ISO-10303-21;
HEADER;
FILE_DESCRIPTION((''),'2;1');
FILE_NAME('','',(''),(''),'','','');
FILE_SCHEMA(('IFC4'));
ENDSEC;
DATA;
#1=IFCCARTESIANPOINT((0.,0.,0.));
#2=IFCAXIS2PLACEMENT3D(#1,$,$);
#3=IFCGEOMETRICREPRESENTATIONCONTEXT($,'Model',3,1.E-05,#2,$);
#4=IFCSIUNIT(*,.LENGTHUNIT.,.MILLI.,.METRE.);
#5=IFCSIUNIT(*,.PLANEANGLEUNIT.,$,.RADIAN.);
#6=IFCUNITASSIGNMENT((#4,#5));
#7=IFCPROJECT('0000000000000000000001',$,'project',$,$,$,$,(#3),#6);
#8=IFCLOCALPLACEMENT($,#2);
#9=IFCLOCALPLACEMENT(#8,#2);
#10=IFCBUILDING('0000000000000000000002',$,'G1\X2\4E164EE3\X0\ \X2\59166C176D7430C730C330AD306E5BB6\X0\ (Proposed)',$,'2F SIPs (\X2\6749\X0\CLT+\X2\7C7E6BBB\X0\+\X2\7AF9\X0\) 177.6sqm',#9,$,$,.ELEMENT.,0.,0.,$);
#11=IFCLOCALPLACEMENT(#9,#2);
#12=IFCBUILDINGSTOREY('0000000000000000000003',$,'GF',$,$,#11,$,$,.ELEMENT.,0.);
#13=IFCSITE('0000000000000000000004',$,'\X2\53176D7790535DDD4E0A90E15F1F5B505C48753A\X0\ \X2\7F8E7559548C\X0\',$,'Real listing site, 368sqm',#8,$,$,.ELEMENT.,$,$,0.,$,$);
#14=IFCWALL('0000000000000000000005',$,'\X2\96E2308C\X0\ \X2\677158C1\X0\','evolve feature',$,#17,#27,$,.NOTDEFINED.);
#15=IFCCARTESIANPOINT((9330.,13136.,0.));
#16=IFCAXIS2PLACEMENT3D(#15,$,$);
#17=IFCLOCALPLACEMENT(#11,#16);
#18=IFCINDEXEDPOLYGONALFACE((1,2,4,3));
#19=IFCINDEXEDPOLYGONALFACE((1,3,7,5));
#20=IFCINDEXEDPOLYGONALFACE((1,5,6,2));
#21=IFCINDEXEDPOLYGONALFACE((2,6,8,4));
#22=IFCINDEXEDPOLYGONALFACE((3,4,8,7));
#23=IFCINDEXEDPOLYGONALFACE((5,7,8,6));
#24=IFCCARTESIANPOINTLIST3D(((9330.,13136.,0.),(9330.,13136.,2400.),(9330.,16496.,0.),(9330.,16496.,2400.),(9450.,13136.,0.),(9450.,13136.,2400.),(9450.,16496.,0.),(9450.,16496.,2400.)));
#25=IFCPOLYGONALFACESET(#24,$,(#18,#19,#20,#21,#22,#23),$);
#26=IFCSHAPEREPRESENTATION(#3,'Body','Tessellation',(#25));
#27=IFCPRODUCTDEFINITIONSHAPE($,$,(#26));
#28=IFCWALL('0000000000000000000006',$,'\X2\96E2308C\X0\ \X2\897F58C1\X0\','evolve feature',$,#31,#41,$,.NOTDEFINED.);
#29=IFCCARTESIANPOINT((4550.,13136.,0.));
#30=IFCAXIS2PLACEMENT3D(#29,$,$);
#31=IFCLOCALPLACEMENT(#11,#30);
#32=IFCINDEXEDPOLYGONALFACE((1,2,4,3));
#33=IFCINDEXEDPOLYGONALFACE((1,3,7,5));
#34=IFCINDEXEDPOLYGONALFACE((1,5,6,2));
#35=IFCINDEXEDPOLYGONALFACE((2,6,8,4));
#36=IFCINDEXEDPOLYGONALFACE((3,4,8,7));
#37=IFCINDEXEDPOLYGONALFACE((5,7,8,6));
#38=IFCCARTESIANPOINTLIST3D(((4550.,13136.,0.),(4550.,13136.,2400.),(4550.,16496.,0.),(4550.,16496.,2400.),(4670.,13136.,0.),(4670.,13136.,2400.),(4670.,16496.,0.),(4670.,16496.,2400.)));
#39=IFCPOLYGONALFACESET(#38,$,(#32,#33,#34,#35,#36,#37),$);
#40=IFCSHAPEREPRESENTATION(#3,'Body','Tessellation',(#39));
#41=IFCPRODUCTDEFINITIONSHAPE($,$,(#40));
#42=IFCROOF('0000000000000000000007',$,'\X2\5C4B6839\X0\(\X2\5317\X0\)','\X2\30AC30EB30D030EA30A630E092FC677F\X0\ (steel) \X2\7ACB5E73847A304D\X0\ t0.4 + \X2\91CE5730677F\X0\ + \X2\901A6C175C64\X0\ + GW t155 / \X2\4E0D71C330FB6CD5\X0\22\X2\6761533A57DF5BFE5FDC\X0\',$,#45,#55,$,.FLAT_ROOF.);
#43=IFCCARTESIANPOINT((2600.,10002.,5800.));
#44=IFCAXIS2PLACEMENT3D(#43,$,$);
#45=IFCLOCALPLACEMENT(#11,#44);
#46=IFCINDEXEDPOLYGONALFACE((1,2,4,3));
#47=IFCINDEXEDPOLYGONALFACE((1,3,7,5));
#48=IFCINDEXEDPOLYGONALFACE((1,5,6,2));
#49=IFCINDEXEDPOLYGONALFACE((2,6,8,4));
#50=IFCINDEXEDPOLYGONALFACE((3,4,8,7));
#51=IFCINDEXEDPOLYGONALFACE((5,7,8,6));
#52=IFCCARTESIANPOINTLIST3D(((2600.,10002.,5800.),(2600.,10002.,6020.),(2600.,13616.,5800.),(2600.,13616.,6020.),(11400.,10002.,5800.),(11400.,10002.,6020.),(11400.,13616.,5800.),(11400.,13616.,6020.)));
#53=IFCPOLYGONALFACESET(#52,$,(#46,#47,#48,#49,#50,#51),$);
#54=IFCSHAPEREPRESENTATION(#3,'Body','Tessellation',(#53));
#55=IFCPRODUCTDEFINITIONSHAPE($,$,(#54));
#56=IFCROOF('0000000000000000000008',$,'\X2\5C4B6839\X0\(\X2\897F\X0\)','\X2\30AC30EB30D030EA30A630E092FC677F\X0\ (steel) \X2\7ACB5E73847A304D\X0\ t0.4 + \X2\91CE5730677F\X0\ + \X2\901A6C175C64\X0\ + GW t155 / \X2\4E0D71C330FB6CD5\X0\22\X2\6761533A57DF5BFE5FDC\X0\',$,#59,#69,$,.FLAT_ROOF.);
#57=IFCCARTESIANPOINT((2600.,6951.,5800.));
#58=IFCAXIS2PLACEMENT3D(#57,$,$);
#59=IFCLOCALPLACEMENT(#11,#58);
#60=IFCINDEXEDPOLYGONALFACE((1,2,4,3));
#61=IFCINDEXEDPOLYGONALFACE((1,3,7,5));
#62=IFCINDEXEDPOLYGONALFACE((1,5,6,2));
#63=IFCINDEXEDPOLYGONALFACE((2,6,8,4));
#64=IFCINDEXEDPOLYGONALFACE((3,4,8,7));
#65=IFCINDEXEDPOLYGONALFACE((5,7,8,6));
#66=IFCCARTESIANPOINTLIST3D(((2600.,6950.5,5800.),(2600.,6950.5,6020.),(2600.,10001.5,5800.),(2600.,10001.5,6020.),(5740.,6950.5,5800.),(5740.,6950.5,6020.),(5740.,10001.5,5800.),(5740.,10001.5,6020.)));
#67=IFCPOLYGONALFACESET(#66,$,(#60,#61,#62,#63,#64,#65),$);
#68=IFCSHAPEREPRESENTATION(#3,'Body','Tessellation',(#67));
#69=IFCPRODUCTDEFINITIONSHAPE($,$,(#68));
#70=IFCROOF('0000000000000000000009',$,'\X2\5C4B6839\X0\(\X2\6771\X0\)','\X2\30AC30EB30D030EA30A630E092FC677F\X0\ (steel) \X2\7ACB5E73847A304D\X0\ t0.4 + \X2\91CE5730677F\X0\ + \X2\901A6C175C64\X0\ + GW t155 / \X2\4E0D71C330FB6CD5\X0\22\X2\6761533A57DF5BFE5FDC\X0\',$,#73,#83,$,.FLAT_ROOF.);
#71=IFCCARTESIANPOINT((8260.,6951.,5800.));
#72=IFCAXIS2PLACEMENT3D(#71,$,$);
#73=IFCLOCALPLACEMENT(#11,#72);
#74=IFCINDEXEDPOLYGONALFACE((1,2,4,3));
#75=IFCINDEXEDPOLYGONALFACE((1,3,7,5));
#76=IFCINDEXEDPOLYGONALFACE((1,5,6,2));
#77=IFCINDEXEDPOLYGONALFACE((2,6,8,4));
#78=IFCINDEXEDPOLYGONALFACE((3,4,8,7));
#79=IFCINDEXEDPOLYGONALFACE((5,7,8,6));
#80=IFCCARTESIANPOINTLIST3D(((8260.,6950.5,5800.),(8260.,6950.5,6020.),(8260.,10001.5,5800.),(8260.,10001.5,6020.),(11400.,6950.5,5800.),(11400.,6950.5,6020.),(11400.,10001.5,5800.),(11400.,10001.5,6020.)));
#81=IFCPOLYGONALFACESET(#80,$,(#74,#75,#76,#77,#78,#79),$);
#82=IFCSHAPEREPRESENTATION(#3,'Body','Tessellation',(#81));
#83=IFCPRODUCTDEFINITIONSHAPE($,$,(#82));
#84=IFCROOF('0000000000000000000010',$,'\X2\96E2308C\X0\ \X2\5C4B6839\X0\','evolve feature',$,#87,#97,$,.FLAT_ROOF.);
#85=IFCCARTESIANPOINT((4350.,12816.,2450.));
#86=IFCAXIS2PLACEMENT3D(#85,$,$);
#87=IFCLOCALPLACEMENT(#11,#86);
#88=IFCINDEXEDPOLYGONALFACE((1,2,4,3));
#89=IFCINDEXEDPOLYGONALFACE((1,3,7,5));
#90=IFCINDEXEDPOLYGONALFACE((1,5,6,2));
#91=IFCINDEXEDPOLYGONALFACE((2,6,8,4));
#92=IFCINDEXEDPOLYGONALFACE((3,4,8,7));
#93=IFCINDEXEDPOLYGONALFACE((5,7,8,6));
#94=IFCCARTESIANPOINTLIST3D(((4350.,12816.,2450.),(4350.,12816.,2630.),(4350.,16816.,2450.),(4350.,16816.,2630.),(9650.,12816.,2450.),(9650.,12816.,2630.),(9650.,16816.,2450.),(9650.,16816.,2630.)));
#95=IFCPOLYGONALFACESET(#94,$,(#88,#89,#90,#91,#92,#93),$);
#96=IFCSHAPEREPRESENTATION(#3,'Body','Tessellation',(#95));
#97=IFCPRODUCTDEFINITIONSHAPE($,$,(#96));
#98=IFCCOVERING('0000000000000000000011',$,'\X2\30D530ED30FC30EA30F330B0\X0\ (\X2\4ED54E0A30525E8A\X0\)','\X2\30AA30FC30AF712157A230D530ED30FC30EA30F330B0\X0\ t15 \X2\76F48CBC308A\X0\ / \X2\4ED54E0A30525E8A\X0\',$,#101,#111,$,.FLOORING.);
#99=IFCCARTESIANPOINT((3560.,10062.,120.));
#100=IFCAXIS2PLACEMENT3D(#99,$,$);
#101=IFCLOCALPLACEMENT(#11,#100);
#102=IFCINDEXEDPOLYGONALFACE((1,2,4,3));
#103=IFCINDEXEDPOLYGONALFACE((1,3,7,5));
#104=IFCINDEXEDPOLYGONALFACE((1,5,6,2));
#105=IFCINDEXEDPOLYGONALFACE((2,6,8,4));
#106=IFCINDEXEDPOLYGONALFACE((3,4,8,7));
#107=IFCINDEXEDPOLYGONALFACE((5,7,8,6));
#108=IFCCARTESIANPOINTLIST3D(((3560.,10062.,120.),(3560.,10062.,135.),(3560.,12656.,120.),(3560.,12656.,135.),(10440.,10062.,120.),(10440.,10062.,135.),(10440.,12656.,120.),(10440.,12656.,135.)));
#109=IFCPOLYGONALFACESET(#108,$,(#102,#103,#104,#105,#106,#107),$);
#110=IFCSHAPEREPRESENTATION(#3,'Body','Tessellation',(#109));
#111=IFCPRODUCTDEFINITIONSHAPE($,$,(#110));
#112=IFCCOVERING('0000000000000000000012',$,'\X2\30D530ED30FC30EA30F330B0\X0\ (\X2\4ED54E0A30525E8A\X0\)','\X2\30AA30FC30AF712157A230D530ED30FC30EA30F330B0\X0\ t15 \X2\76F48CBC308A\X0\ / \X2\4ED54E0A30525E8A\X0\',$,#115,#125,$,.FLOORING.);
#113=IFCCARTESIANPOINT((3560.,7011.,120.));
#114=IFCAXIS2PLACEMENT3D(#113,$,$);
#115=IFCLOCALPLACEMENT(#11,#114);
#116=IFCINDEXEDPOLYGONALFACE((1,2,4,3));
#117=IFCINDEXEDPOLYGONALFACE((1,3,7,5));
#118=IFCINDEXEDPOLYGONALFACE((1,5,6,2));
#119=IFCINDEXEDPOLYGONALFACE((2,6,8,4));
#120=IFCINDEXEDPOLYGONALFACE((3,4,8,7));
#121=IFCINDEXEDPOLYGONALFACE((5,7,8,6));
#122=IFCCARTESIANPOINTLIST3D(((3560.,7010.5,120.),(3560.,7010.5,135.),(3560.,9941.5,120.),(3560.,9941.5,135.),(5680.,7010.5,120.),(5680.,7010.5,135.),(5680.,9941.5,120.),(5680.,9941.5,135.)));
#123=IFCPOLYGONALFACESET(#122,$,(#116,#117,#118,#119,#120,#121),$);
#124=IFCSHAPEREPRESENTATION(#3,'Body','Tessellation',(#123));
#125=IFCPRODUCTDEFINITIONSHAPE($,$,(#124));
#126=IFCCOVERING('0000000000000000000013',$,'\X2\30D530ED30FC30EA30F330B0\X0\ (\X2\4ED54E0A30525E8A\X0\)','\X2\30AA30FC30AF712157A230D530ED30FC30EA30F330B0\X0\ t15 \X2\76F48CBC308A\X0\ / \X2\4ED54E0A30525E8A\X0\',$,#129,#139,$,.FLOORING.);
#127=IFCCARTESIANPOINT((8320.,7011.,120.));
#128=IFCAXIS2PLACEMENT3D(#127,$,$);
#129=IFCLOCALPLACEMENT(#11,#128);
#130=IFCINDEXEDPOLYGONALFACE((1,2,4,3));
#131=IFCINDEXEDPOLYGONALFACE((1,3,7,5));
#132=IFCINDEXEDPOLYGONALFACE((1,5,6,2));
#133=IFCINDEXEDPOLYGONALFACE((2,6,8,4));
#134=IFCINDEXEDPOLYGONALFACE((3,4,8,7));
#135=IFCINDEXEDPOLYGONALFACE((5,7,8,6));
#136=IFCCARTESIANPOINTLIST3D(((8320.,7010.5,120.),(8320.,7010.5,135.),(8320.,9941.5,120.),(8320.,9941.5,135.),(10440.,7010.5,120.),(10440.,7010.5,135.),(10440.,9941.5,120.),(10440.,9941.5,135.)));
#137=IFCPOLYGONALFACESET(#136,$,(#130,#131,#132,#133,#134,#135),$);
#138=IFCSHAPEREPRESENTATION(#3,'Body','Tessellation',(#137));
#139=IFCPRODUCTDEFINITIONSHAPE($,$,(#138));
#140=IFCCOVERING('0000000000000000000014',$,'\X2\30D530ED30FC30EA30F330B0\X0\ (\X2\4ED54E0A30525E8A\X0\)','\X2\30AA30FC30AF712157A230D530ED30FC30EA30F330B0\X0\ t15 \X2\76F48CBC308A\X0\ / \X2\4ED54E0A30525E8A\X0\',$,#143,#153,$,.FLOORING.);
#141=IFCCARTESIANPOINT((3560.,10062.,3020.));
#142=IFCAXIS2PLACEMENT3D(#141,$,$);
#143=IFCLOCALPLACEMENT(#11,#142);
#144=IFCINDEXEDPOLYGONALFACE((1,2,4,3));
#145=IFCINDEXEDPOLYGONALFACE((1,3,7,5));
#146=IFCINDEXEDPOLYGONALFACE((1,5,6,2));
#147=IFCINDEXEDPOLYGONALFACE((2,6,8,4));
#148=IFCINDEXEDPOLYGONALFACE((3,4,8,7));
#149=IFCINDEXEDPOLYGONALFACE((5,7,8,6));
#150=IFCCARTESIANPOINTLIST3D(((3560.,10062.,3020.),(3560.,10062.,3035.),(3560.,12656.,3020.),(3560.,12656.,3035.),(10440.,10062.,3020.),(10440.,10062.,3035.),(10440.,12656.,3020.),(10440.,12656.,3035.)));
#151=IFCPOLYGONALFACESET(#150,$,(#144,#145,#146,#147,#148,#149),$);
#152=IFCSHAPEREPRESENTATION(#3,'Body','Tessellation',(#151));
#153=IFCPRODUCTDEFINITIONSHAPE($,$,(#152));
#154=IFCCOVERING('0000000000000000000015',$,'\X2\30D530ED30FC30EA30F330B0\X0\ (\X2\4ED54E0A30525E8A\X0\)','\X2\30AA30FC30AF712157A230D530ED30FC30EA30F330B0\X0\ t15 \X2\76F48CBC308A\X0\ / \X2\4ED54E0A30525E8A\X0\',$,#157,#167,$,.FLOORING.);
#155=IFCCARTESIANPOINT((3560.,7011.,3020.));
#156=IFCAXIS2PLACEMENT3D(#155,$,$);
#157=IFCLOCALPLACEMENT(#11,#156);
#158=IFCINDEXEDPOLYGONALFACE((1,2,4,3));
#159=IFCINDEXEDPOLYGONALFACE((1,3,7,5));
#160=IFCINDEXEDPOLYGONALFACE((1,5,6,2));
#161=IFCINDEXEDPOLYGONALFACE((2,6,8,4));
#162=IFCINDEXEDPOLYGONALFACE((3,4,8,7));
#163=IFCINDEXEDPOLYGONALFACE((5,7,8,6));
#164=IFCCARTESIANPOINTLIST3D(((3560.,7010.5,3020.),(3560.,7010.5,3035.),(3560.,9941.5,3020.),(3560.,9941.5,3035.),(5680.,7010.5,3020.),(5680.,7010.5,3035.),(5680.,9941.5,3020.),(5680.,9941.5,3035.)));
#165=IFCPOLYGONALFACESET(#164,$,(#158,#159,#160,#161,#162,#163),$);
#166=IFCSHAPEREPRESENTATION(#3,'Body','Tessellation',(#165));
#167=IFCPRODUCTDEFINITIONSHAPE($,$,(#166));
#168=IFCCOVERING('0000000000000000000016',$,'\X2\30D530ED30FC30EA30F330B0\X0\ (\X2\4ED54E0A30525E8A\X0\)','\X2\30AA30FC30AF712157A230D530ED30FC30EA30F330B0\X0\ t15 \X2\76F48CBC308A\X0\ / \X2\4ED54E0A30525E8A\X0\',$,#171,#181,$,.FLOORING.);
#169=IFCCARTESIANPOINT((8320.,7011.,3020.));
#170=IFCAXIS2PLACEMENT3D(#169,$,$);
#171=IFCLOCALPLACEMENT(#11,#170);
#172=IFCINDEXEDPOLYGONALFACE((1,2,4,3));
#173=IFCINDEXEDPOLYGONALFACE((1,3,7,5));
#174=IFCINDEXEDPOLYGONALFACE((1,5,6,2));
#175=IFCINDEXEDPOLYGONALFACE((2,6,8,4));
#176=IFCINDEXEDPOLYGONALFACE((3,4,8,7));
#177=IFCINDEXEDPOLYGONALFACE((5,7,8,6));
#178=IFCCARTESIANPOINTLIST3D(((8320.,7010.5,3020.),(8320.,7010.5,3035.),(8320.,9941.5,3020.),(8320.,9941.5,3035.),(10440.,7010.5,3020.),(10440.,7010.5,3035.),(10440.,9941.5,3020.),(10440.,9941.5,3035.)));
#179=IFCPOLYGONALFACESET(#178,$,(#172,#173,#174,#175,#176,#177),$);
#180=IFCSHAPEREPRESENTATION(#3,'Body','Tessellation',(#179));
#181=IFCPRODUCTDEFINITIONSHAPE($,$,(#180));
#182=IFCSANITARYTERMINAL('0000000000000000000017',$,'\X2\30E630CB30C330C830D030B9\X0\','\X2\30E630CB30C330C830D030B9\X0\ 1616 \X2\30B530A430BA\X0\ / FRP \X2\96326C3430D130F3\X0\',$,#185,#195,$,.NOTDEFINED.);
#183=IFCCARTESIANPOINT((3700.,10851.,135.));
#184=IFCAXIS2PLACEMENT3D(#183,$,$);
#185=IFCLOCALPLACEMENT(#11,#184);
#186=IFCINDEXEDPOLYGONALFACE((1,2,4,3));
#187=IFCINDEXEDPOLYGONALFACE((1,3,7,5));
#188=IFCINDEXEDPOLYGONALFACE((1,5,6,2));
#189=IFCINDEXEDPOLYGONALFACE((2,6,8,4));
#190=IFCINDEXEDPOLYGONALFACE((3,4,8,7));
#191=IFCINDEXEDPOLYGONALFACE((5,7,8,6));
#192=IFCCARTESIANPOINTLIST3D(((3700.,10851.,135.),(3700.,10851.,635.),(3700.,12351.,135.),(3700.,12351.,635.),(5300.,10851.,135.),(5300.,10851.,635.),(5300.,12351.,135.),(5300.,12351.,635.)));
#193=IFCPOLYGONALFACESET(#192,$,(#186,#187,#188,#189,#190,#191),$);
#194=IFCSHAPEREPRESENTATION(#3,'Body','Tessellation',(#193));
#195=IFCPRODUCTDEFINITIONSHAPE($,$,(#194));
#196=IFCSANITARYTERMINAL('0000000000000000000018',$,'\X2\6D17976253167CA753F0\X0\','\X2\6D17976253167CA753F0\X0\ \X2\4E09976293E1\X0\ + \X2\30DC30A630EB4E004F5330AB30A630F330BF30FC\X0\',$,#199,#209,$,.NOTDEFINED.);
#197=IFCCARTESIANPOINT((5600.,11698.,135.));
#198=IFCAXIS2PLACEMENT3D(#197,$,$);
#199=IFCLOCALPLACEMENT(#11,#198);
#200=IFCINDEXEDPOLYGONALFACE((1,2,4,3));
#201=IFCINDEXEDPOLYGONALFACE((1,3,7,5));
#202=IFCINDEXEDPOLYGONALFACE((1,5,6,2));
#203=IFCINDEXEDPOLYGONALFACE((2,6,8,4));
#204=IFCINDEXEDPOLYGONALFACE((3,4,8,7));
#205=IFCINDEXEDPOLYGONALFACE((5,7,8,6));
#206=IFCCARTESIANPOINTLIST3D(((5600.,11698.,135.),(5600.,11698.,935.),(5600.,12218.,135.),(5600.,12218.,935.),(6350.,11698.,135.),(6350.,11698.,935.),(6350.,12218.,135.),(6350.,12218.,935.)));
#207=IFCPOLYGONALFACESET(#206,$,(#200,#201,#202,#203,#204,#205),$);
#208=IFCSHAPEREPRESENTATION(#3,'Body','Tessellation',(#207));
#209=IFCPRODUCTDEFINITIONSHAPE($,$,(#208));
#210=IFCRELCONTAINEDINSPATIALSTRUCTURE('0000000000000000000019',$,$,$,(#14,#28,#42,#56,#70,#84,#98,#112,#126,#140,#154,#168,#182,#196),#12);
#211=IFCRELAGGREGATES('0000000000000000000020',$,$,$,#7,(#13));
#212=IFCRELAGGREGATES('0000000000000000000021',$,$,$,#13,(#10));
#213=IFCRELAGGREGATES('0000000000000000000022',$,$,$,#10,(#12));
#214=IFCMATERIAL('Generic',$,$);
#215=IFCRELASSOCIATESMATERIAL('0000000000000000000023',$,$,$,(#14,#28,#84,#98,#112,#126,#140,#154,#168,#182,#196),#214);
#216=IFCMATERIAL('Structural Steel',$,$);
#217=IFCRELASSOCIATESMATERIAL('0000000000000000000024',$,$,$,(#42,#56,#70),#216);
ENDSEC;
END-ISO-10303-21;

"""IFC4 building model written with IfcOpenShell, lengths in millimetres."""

from ifc_helpers import new_model, si_unit, frame, frame_2d, origin, place, context, project, spatial, rectangle, extrude, material, element, save


model = new_model("IFC4")

# Units and contexts
model_context = context("Model", 3, precision=1e-05, world=origin())
ifc_project = project(units=[si_unit("LENGTHUNIT", "METRE", prefix="MILLI"), si_unit("PLANEANGLEUNIT", "RADIAN")], contexts=[model_context])

# Site, building, storey
site_placement = place(None, origin())
site = spatial("IfcSite", under=ifc_project, at=site_placement, Name="北海道川上郡弟子屈町 美留和", ObjectType="Real listing site, 368sqm", CompositionType="ELEMENT", RefElevation=0.0)
building_placement = place(site_placement, origin())
building = spatial("IfcBuilding", under=site, at=building_placement, Name="G1世代 外気浴デッキの家 (Proposed)", ObjectType="2F SIPs (杉CLT+籾殻+竹) 177.6sqm", CompositionType="ELEMENT", ElevationOfRefHeight=0.0, ElevationOfTerrain=0.0)
storey_placement = place(building_placement, origin())
storey = spatial("IfcBuildingStorey", under=building, at=storey_placement, Name="GF", CompositionType="ELEMENT", Elevation=0.0)

# Shared definitions
ifc_material_1 = material(Name="Generic")

# Walls
wall_1_placement = place(storey_placement, frame((9330.0, 13136.0, 0.0)))
element("IfcWall", 1, at=wall_1_placement, inside=storey, material=ifc_material_1, Name="離れ 東壁", Description="evolve feature", PredefinedType="NOTDEFINED", context=model_context, shape_type="SweptSolid", body=[
    extrude(rectangle(XDim=120.0, YDim=3360.0, at=frame_2d((60.0, 1680.0))), frame((9330.0, 13136.0, 0.0)), (0.0, 0.0, 1.0), 2400.0),
])
wall_2_placement = place(storey_placement, frame((4550.0, 13136.0, 0.0)))
element("IfcWall", 2, at=wall_2_placement, inside=storey, material=ifc_material_1, Name="離れ 西壁", Description="evolve feature", PredefinedType="NOTDEFINED", context=model_context, shape_type="SweptSolid", body=[
    extrude(rectangle(XDim=120.0, YDim=3360.0, at=frame_2d((60.0, 1680.0))), frame((4550.0, 13136.0, 0.0)), (0.0, 0.0, 1.0), 2400.0),
])

# Roofs
ifc_material_2 = material(Name="Structural Steel")
for number, where, name in (
    (3, (2600.0, 10002.0, 5800.0), "屋根(北)"),
):
    element("IfcRoof", number, at=place(storey_placement, frame(where)), inside=storey, material=ifc_material_2, Name=name, Description="ガルバリウム鋼板 (steel) 立平葺き t0.4 + 野地板 + 通気層 + GW t155 / 不燃・法22条区域対応", PredefinedType="FLAT_ROOF", context=model_context, shape_type="SweptSolid", body=[
        extrude(rectangle(XDim=8800.0, YDim=3614.0, at=frame_2d((4400.0, 1807.0))), frame((2600.0, 10002.0, 5800.0)), (0.0, 0.0, 1.0), 220.0),
    ])
roof_1_placement = place(storey_placement, frame((2600.0, 6951.0, 5800.0)))
element("IfcRoof", 4, at=roof_1_placement, inside=storey, material=ifc_material_2, Name="屋根(西)", Description="ガルバリウム鋼板 (steel) 立平葺き t0.4 + 野地板 + 通気層 + GW t155 / 不燃・法22条区域対応", PredefinedType="FLAT_ROOF", context=model_context, shape_type="SweptSolid", body=[
    extrude(rectangle(XDim=3140.0, YDim=3051.0, at=frame_2d((1570.0, 1525.0))), frame((2600.0, 6951.0, 5800.0)), (0.0, 0.0, 1.0), 220.0),
])
roof_2_placement = place(storey_placement, frame((8260.0, 6951.0, 5800.0)))
element("IfcRoof", 5, at=roof_2_placement, inside=storey, material=ifc_material_2, Name="屋根(東)", Description="ガルバリウム鋼板 (steel) 立平葺き t0.4 + 野地板 + 通気層 + GW t155 / 不燃・法22条区域対応", PredefinedType="FLAT_ROOF", context=model_context, shape_type="SweptSolid", body=[
    extrude(rectangle(XDim=3140.0, YDim=3051.0, at=frame_2d((1570.0, 1525.0))), frame((8260.0, 6951.0, 5800.0)), (0.0, 0.0, 1.0), 220.0),
])
roof_3_placement = place(storey_placement, frame((4350.0, 12816.0, 2450.0)))
element("IfcRoof", 6, at=roof_3_placement, inside=storey, material=ifc_material_1, Name="離れ 屋根", Description="evolve feature", PredefinedType="FLAT_ROOF", context=model_context, shape_type="SweptSolid", body=[
    extrude(rectangle(XDim=5300.0, YDim=4000.0, at=frame_2d((2650.0, 2000.0))), frame((4350.0, 12816.0, 2450.0)), (0.0, 0.0, 1.0), 180.0),
])

# Coverings
covering_1_placement = place(storey_placement, frame((3560.0, 10062.0, 120.0)))
element("IfcCovering", 7, at=covering_1_placement, inside=storey, material=ifc_material_1, Name="フローリング (仕上げ床)", Description="オーク無垢フローリング t15 直貼り / 仕上げ床", PredefinedType="FLOORING", context=model_context, shape_type="SweptSolid", body=[
    extrude(rectangle(XDim=6880.0, YDim=2594.0, at=frame_2d((3440.0, 1297.0))), frame((3560.0, 10062.0, 120.0)), (0.0, 0.0, 1.0), 15.0),
])
covering_2_placement = place(storey_placement, frame((3560.0, 7011.0, 120.0)))
element("IfcCovering", 8, at=covering_2_placement, inside=storey, material=ifc_material_1, Name="フローリング (仕上げ床)", Description="オーク無垢フローリング t15 直貼り / 仕上げ床", PredefinedType="FLOORING", context=model_context, shape_type="SweptSolid", body=[
    extrude(rectangle(XDim=2120.0, YDim=2931.0, at=frame_2d((1060.0, 1465.0))), frame((3560.0, 7011.0, 120.0)), (0.0, 0.0, 1.0), 15.0),
])
covering_3_placement = place(storey_placement, frame((8320.0, 7011.0, 120.0)))
element("IfcCovering", 9, at=covering_3_placement, inside=storey, material=ifc_material_1, Name="フローリング (仕上げ床)", Description="オーク無垢フローリング t15 直貼り / 仕上げ床", PredefinedType="FLOORING", context=model_context, shape_type="SweptSolid", body=[
    extrude(rectangle(XDim=2120.0, YDim=2931.0, at=frame_2d((1060.0, 1465.0))), frame((8320.0, 7011.0, 120.0)), (0.0, 0.0, 1.0), 15.0),
])
covering_4_placement = place(storey_placement, frame((3560.0, 10062.0, 3020.0)))
element("IfcCovering", 10, at=covering_4_placement, inside=storey, material=ifc_material_1, Name="フローリング (仕上げ床)", Description="オーク無垢フローリング t15 直貼り / 仕上げ床", PredefinedType="FLOORING", context=model_context, shape_type="SweptSolid", body=[
    extrude(rectangle(XDim=6880.0, YDim=2594.0, at=frame_2d((3440.0, 1297.0))), frame((3560.0, 10062.0, 3020.0)), (0.0, 0.0, 1.0), 15.0),
])
covering_5_placement = place(storey_placement, frame((3560.0, 7011.0, 3020.0)))
element("IfcCovering", 11, at=covering_5_placement, inside=storey, material=ifc_material_1, Name="フローリング (仕上げ床)", Description="オーク無垢フローリング t15 直貼り / 仕上げ床", PredefinedType="FLOORING", context=model_context, shape_type="SweptSolid", body=[
    extrude(rectangle(XDim=2120.0, YDim=2931.0, at=frame_2d((1060.0, 1465.0))), frame((3560.0, 7011.0, 3020.0)), (0.0, 0.0, 1.0), 15.0),
])
covering_6_placement = place(storey_placement, frame((8320.0, 7011.0, 3020.0)))
element("IfcCovering", 12, at=covering_6_placement, inside=storey, material=ifc_material_1, Name="フローリング (仕上げ床)", Description="オーク無垢フローリング t15 直貼り / 仕上げ床", PredefinedType="FLOORING", context=model_context, shape_type="SweptSolid", body=[
    extrude(rectangle(XDim=2120.0, YDim=2931.0, at=frame_2d((1060.0, 1465.0))), frame((8320.0, 7011.0, 3020.0)), (0.0, 0.0, 1.0), 15.0),
])

# Sanitary terminals
sanitary_terminal_1_placement = place(storey_placement, frame((3700.0, 10851.0, 135.0)))
element("IfcSanitaryTerminal", 13, at=sanitary_terminal_1_placement, inside=storey, material=ifc_material_1, Name="ユニットバス", Description="ユニットバス 1616 サイズ / FRP 防水パン", PredefinedType="NOTDEFINED", context=model_context, shape_type="SweptSolid", body=[
    extrude(rectangle(XDim=1600.0, YDim=1500.0, at=frame_2d((800.0, 750.0))), frame((3700.0, 10851.0, 135.0)), (0.0, 0.0, 1.0), 500.0),
])
sanitary_terminal_2_placement = place(storey_placement, frame((5600.0, 11698.0, 135.0)))
element("IfcSanitaryTerminal", 14, at=sanitary_terminal_2_placement, inside=storey, material=ifc_material_1, Name="洗面化粧台", Description="洗面化粧台 三面鏡 + ボウル一体カウンター", PredefinedType="NOTDEFINED", context=model_context, shape_type="SweptSolid", body=[
    extrude(rectangle(XDim=750.0, YDim=520.0, at=frame_2d((375.0, 260.0))), frame((5600.0, 11698.0, 135.0)), (0.0, 0.0, 1.0), 800.0),
])

save(model, "model.ifc")
